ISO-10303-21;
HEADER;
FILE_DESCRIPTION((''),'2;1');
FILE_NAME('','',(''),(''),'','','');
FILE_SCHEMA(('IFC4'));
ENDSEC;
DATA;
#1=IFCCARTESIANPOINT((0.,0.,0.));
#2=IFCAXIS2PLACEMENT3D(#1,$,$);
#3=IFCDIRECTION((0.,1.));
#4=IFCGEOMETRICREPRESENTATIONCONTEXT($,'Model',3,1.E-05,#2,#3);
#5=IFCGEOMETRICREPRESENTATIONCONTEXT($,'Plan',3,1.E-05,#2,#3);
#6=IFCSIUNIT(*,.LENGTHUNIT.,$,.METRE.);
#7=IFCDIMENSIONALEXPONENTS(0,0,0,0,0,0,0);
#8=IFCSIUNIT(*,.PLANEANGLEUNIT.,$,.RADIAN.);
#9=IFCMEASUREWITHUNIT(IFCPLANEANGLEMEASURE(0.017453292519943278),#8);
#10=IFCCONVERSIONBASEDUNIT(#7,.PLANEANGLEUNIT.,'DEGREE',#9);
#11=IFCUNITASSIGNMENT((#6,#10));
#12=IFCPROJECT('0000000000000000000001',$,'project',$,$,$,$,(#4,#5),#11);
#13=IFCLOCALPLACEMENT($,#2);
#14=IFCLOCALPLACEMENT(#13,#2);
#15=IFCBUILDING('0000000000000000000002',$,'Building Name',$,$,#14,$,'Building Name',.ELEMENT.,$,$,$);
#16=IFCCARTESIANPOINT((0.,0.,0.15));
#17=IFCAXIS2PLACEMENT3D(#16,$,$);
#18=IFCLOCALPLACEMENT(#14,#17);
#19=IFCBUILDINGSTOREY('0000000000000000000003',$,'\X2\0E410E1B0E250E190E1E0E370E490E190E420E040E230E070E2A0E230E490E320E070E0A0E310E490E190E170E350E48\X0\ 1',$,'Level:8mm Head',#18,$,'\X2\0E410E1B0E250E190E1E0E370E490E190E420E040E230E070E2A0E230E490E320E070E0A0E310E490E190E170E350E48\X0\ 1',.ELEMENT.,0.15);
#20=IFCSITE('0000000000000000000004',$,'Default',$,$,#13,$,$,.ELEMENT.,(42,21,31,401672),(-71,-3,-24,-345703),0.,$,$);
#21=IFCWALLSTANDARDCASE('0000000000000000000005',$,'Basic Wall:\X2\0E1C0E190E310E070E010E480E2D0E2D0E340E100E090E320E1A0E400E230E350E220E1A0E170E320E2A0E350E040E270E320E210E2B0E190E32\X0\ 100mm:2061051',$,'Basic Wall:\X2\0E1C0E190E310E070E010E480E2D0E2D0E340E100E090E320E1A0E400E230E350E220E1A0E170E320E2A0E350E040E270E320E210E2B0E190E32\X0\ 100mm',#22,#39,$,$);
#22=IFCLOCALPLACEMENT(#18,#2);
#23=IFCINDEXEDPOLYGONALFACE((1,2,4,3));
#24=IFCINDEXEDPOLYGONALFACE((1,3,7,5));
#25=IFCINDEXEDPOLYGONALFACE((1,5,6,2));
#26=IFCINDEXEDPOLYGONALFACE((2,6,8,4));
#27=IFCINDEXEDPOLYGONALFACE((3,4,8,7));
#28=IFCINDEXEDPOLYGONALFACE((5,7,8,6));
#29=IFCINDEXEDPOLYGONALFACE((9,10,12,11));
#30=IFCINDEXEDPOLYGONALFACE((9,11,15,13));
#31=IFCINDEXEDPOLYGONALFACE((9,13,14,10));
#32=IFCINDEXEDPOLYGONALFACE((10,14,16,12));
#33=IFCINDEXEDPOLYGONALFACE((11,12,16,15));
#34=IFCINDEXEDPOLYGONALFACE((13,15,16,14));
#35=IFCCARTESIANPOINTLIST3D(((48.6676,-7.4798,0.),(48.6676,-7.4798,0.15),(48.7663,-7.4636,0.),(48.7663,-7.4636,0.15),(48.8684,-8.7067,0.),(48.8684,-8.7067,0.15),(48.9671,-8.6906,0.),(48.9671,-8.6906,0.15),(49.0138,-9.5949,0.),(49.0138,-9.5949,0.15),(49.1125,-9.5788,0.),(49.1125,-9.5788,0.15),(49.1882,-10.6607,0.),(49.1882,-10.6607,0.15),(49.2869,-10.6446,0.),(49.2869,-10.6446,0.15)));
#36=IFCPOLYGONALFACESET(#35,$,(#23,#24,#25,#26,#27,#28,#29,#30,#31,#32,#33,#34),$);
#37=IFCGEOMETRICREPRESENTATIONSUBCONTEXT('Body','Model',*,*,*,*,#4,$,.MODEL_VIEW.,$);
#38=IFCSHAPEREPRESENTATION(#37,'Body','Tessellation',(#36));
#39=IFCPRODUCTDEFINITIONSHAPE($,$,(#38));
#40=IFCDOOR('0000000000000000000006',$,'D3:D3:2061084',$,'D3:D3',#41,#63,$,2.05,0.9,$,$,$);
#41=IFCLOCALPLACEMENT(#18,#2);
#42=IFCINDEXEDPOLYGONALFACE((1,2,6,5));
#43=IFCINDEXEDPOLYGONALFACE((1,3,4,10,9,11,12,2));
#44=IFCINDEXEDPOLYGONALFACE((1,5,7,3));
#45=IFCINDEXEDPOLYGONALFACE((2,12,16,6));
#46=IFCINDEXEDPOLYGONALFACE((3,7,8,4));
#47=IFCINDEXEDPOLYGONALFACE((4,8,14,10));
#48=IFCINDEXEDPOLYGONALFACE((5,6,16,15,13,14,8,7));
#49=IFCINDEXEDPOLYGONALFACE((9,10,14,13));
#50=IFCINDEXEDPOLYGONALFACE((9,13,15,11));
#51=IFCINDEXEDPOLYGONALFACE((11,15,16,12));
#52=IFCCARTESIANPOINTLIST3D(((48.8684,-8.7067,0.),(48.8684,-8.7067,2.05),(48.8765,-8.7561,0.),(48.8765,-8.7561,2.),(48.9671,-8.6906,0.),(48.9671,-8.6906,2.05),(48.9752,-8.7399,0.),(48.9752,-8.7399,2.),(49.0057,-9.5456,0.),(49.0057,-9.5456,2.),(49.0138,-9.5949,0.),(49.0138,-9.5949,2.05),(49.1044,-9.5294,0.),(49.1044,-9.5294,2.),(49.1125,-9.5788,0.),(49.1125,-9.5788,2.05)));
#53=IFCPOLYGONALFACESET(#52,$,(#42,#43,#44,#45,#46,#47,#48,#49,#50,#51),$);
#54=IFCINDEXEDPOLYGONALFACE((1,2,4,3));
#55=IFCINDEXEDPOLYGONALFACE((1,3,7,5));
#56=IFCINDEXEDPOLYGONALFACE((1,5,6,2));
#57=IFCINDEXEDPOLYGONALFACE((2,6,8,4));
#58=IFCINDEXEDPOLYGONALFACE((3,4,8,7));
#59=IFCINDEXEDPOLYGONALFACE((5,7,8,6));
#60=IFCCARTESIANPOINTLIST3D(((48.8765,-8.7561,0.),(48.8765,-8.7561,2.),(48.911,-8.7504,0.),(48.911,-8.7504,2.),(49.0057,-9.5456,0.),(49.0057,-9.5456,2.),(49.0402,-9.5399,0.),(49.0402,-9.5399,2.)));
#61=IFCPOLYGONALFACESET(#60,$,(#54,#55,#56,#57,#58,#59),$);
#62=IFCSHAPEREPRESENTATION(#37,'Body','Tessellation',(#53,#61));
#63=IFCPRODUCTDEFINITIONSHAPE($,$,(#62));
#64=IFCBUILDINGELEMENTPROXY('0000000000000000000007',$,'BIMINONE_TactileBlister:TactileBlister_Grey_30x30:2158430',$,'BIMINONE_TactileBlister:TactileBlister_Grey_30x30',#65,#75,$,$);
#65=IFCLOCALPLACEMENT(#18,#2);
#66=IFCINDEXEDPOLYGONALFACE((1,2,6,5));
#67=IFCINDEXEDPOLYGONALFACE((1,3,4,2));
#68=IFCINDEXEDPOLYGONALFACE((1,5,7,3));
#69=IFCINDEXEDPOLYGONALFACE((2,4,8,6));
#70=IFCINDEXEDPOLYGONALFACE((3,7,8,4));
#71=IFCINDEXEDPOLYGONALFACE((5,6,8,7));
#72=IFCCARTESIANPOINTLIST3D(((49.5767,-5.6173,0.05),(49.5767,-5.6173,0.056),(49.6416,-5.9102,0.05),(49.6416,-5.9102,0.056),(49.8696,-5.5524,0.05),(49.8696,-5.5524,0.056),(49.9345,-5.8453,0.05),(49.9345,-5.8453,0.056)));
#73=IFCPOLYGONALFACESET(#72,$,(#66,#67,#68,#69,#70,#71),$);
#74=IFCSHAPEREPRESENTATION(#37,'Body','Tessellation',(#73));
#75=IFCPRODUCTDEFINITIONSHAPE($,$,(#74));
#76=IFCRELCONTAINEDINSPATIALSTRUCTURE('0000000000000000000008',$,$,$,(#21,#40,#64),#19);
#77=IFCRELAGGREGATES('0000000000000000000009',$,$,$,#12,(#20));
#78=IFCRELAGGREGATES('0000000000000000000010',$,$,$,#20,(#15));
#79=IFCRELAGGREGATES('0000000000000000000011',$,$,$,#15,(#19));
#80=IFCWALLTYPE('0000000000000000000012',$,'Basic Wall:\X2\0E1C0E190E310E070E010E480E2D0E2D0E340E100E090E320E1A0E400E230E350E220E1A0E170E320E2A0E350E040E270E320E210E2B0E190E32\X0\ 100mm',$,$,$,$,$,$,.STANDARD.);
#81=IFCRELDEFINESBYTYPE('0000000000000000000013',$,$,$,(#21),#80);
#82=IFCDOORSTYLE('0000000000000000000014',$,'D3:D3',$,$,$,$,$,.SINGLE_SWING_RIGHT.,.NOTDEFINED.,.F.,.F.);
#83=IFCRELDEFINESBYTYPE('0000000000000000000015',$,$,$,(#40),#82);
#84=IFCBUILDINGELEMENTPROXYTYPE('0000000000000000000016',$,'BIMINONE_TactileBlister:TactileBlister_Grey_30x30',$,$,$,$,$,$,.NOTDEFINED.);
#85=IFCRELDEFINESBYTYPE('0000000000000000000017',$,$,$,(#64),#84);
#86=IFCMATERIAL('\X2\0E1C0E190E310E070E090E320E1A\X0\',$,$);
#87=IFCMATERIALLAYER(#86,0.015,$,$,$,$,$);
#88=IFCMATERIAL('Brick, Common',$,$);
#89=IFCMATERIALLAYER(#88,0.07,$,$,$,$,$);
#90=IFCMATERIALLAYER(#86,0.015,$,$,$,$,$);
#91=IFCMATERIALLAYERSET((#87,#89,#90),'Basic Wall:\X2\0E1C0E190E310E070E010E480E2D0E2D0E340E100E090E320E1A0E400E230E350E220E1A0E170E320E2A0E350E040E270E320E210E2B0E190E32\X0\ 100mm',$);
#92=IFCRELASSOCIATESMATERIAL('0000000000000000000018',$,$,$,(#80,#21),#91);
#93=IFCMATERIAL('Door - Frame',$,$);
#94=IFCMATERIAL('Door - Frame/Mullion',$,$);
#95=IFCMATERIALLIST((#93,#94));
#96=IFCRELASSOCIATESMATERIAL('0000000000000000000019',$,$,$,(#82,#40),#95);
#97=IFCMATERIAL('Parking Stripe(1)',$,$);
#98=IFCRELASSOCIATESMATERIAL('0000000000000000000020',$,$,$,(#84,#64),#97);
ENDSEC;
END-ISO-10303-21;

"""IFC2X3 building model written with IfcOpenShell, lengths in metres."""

from ifc_helpers import new_model, entity, si_unit, converted_unit, direction, frame, frame_2d, origin, origin_2d_with_axis, place, context, subcontext, project, spatial, polyline, rectangle, outline, extrude, clip, halfspace, source, transform, mapped, material, material_list, layer, layer_set, layer_usage, type_object, type_shapes, element, fill, save


model = new_model("IFC2X3")

# Units and contexts
model_context = context("Model", 3, precision=1e-05, world=origin(), true_north=direction((0.0, 1.0)))
plan_context = context("Plan", 3, precision=1e-05, world=origin(), true_north=direction((0.0, 1.0)))
body_context = subcontext(model_context, "Body", "Model", "MODEL_VIEW")
ifc_project = project(units=[si_unit("LENGTHUNIT", "METRE"), converted_unit("PLANEANGLEUNIT", "DEGREE", entity("IfcPlaneAngleMeasure", 0.017453292519943278), si_unit("PLANEANGLEUNIT", "RADIAN"), dimensions=[0, 0, 0, 0, 0, 0, 0])], contexts=[model_context, plan_context])

# Site, building, storey
site_placement = place(None, origin())
site = spatial("IfcSite", under=ifc_project, at=site_placement, Name="Default", CompositionType="ELEMENT", RefLatitude=(42, 21, 31, 401672), RefLongitude=(-71, -3, -24, -345703), RefElevation=0.0)
building_placement = place(site_placement, origin())
building = spatial("IfcBuilding", under=site, at=building_placement, Name="Building Name", LongName="Building Name", CompositionType="ELEMENT")
storey_placement = place(building_placement, frame((0.0, 0.0, 0.15)))
storey = spatial("IfcBuildingStorey", under=building, at=storey_placement, Name="แปลนพื้นโครงสร้างชั้นที่ 1", ObjectType="Level:8mm Head", LongName="แปลนพื้นโครงสร้างชั้นที่ 1", CompositionType="ELEMENT", Elevation=0.15)

# Shared definitions
ifc_material_1 = material(Name="ผนังฉาบ")
ifc_layer_1 = layer(ifc_material_1, 0.015)
ifc_material_2 = material(Name="Brick, Common")
ifc_layer_2 = layer(ifc_material_2, 0.07)
ifc_layer_3 = layer(ifc_material_1, 0.015)
ifc_layer_set = layer_set([ifc_layer_1, ifc_layer_2, ifc_layer_3], Name="Basic Wall:ผนังก่ออิฐฉาบเรียบทาสีความหนา 100mm")
wall_type = type_object("IfcWallType", Name="Basic Wall:ผนังก่ออิฐฉาบเรียบทาสีความหนา 100mm", PredefinedType="STANDARD", material=ifc_layer_set)

# Shared definitions
ifc_material_3 = material(Name="Door - Frame")
ifc_material_4 = material(Name="Door - Frame/Mullion")
ifc_material_list = material_list([ifc_material_3, ifc_material_4])
door_style_1 = type_object("IfcDoorStyle", Name="D3:D3", ConstructionType="NOTDEFINED", OperationType="SINGLE_SWING_RIGHT", ParameterTakesPrecedence=False, Sizeable=False, material=ifc_material_list)
shared_shape_1 = source(origin(), body_context, "Body", "SweptSolid", [
    extrude(outline(polyline([(-0.45, -1.0125), (-0.4, -1.0125), (-0.4, 0.9875), (0.4, 0.9875), (0.4, -1.0125), (0.45, -1.0125), (0.45, 1.0375), (-0.45, 1.0375), (-0.45, -1.0125)])), frame((0.45, 0.1, 1.0125), z_axis=(0.0, -1.0, 0.0), x_axis=(1.0, 0.0, 0.0)), (0.0, 0.0, 1.0), 0.1),
    extrude(rectangle(XDim=0.035, YDim=0.8, at=origin_2d_with_axis()), frame((0.45, 0.0825, 0.0), z_axis=(0.0, 0.0, 1.0), x_axis=(0.0, -1.0, 0.0)), (0.0, 0.0, 1.0), 2.0),
])
type_shapes(door_style_1, [shared_shape_1])

# Wall, opening, door
ifc_layer_usage_1 = layer_usage(ifc_layer_set, "AXIS2", "NEGATIVE", 0.05)
wall_1_placement = place(storey_placement, frame((48.717, -7.4717, 0.0), z_axis=(0.0, 0.0, 1.0), x_axis=(0.161513, -0.986871, 0.0)))
wall_1 = element("IfcWallStandardCase", 1, at=wall_1_placement, inside=storey, type_object=wall_type, material=ifc_layer_usage_1, Name="Basic Wall:ผนังก่ออิฐฉาบเรียบทาสีความหนา 100mm:2061051", ObjectType="Basic Wall:ผนังก่ออิฐฉาบเรียบทาสีความหนา 100mm", context=body_context, shape_type="Clipping", body=[
    clip(extrude(rectangle(XDim=3.2233, YDim=0.1, at=frame_2d((1.6116, 0.0), x_axis=(1.0, 0.0))), origin(), (0.0, 0.0, 1.0), 0.15), halfspace(origin(), True)),
])
opening_1_placement = place(wall_1_placement, frame((2.1433, 0.05, 0.0)))
opening_1 = element("IfcOpeningElement", 2, at=opening_1_placement, cuts=wall_1, ObjectType="Opening", context=body_context, shape_type="SweptSolid", body=[
    extrude(rectangle(XDim=2.05, YDim=0.9, at=frame_2d((1.025, 0.45), x_axis=(1.0, 0.0))), frame((0.0, 0.0, 0.0), z_axis=(0.0, -1.0, 0.0), x_axis=(0.0, 0.0, 1.0)), (0.0, 0.0, 1.0), 0.1),
])
door_1_placement = place(opening_1_placement, frame((0.0, 0.0, 0.0), z_axis=(0.0, 0.0, 1.0), x_axis=(-1.0, 0.0, 0.0)))
door_1 = element("IfcDoor", 3, at=door_1_placement, inside=storey, type_object=door_style_1, material=ifc_material_list, Name="D3:D3:2061084", ObjectType="D3:D3", OverallHeight=2.05, OverallWidth=0.9, context=body_context, shape_type="MappedRepresentation", body=[
    mapped(shared_shape_1, transform((0.0, 0.0, 0.0), scale=1.0)),
])
fill(opening_1, door_1)

# Building element proxy
ifc_material_5 = material(Name="Parking Stripe(1)")
building_element_proxy_type = type_object("IfcBuildingElementProxyType", Name="BIMINONE_TactileBlister:TactileBlister_Grey_30x30", PredefinedType="NOTDEFINED", material=ifc_material_5)
shared_shape_2 = source(origin(), body_context, "Body", "SweptSolid", [
    extrude(rectangle(XDim=0.3, YDim=0.3, at=origin_2d_with_axis()), frame((0.15, -0.15, 0.0), z_axis=(0.0, 0.0, 1.0), x_axis=(-1.0, 0.0, 0.0)), (0.0, 0.0, 1.0), 0.006),
])
type_shapes(building_element_proxy_type, [shared_shape_2])
proxy_placement = place(storey_placement, frame((49.5767, -5.6173, 0.05), z_axis=(0.0, 0.0, 1.0), x_axis=(0.976323, 0.216316, 0.0)))
element("IfcBuildingElementProxy", 4, at=proxy_placement, inside=storey, type_object=building_element_proxy_type, material=ifc_material_5, Name="BIMINONE_TactileBlister:TactileBlister_Grey_30x30:2158430", ObjectType="BIMINONE_TactileBlister:TactileBlister_Grey_30x30", context=body_context, shape_type="MappedRepresentation", body=[
    mapped(shared_shape_2, transform((0.0, 0.0, 0.0), scale=1.0)),
])

save(model, "model.ifc")
